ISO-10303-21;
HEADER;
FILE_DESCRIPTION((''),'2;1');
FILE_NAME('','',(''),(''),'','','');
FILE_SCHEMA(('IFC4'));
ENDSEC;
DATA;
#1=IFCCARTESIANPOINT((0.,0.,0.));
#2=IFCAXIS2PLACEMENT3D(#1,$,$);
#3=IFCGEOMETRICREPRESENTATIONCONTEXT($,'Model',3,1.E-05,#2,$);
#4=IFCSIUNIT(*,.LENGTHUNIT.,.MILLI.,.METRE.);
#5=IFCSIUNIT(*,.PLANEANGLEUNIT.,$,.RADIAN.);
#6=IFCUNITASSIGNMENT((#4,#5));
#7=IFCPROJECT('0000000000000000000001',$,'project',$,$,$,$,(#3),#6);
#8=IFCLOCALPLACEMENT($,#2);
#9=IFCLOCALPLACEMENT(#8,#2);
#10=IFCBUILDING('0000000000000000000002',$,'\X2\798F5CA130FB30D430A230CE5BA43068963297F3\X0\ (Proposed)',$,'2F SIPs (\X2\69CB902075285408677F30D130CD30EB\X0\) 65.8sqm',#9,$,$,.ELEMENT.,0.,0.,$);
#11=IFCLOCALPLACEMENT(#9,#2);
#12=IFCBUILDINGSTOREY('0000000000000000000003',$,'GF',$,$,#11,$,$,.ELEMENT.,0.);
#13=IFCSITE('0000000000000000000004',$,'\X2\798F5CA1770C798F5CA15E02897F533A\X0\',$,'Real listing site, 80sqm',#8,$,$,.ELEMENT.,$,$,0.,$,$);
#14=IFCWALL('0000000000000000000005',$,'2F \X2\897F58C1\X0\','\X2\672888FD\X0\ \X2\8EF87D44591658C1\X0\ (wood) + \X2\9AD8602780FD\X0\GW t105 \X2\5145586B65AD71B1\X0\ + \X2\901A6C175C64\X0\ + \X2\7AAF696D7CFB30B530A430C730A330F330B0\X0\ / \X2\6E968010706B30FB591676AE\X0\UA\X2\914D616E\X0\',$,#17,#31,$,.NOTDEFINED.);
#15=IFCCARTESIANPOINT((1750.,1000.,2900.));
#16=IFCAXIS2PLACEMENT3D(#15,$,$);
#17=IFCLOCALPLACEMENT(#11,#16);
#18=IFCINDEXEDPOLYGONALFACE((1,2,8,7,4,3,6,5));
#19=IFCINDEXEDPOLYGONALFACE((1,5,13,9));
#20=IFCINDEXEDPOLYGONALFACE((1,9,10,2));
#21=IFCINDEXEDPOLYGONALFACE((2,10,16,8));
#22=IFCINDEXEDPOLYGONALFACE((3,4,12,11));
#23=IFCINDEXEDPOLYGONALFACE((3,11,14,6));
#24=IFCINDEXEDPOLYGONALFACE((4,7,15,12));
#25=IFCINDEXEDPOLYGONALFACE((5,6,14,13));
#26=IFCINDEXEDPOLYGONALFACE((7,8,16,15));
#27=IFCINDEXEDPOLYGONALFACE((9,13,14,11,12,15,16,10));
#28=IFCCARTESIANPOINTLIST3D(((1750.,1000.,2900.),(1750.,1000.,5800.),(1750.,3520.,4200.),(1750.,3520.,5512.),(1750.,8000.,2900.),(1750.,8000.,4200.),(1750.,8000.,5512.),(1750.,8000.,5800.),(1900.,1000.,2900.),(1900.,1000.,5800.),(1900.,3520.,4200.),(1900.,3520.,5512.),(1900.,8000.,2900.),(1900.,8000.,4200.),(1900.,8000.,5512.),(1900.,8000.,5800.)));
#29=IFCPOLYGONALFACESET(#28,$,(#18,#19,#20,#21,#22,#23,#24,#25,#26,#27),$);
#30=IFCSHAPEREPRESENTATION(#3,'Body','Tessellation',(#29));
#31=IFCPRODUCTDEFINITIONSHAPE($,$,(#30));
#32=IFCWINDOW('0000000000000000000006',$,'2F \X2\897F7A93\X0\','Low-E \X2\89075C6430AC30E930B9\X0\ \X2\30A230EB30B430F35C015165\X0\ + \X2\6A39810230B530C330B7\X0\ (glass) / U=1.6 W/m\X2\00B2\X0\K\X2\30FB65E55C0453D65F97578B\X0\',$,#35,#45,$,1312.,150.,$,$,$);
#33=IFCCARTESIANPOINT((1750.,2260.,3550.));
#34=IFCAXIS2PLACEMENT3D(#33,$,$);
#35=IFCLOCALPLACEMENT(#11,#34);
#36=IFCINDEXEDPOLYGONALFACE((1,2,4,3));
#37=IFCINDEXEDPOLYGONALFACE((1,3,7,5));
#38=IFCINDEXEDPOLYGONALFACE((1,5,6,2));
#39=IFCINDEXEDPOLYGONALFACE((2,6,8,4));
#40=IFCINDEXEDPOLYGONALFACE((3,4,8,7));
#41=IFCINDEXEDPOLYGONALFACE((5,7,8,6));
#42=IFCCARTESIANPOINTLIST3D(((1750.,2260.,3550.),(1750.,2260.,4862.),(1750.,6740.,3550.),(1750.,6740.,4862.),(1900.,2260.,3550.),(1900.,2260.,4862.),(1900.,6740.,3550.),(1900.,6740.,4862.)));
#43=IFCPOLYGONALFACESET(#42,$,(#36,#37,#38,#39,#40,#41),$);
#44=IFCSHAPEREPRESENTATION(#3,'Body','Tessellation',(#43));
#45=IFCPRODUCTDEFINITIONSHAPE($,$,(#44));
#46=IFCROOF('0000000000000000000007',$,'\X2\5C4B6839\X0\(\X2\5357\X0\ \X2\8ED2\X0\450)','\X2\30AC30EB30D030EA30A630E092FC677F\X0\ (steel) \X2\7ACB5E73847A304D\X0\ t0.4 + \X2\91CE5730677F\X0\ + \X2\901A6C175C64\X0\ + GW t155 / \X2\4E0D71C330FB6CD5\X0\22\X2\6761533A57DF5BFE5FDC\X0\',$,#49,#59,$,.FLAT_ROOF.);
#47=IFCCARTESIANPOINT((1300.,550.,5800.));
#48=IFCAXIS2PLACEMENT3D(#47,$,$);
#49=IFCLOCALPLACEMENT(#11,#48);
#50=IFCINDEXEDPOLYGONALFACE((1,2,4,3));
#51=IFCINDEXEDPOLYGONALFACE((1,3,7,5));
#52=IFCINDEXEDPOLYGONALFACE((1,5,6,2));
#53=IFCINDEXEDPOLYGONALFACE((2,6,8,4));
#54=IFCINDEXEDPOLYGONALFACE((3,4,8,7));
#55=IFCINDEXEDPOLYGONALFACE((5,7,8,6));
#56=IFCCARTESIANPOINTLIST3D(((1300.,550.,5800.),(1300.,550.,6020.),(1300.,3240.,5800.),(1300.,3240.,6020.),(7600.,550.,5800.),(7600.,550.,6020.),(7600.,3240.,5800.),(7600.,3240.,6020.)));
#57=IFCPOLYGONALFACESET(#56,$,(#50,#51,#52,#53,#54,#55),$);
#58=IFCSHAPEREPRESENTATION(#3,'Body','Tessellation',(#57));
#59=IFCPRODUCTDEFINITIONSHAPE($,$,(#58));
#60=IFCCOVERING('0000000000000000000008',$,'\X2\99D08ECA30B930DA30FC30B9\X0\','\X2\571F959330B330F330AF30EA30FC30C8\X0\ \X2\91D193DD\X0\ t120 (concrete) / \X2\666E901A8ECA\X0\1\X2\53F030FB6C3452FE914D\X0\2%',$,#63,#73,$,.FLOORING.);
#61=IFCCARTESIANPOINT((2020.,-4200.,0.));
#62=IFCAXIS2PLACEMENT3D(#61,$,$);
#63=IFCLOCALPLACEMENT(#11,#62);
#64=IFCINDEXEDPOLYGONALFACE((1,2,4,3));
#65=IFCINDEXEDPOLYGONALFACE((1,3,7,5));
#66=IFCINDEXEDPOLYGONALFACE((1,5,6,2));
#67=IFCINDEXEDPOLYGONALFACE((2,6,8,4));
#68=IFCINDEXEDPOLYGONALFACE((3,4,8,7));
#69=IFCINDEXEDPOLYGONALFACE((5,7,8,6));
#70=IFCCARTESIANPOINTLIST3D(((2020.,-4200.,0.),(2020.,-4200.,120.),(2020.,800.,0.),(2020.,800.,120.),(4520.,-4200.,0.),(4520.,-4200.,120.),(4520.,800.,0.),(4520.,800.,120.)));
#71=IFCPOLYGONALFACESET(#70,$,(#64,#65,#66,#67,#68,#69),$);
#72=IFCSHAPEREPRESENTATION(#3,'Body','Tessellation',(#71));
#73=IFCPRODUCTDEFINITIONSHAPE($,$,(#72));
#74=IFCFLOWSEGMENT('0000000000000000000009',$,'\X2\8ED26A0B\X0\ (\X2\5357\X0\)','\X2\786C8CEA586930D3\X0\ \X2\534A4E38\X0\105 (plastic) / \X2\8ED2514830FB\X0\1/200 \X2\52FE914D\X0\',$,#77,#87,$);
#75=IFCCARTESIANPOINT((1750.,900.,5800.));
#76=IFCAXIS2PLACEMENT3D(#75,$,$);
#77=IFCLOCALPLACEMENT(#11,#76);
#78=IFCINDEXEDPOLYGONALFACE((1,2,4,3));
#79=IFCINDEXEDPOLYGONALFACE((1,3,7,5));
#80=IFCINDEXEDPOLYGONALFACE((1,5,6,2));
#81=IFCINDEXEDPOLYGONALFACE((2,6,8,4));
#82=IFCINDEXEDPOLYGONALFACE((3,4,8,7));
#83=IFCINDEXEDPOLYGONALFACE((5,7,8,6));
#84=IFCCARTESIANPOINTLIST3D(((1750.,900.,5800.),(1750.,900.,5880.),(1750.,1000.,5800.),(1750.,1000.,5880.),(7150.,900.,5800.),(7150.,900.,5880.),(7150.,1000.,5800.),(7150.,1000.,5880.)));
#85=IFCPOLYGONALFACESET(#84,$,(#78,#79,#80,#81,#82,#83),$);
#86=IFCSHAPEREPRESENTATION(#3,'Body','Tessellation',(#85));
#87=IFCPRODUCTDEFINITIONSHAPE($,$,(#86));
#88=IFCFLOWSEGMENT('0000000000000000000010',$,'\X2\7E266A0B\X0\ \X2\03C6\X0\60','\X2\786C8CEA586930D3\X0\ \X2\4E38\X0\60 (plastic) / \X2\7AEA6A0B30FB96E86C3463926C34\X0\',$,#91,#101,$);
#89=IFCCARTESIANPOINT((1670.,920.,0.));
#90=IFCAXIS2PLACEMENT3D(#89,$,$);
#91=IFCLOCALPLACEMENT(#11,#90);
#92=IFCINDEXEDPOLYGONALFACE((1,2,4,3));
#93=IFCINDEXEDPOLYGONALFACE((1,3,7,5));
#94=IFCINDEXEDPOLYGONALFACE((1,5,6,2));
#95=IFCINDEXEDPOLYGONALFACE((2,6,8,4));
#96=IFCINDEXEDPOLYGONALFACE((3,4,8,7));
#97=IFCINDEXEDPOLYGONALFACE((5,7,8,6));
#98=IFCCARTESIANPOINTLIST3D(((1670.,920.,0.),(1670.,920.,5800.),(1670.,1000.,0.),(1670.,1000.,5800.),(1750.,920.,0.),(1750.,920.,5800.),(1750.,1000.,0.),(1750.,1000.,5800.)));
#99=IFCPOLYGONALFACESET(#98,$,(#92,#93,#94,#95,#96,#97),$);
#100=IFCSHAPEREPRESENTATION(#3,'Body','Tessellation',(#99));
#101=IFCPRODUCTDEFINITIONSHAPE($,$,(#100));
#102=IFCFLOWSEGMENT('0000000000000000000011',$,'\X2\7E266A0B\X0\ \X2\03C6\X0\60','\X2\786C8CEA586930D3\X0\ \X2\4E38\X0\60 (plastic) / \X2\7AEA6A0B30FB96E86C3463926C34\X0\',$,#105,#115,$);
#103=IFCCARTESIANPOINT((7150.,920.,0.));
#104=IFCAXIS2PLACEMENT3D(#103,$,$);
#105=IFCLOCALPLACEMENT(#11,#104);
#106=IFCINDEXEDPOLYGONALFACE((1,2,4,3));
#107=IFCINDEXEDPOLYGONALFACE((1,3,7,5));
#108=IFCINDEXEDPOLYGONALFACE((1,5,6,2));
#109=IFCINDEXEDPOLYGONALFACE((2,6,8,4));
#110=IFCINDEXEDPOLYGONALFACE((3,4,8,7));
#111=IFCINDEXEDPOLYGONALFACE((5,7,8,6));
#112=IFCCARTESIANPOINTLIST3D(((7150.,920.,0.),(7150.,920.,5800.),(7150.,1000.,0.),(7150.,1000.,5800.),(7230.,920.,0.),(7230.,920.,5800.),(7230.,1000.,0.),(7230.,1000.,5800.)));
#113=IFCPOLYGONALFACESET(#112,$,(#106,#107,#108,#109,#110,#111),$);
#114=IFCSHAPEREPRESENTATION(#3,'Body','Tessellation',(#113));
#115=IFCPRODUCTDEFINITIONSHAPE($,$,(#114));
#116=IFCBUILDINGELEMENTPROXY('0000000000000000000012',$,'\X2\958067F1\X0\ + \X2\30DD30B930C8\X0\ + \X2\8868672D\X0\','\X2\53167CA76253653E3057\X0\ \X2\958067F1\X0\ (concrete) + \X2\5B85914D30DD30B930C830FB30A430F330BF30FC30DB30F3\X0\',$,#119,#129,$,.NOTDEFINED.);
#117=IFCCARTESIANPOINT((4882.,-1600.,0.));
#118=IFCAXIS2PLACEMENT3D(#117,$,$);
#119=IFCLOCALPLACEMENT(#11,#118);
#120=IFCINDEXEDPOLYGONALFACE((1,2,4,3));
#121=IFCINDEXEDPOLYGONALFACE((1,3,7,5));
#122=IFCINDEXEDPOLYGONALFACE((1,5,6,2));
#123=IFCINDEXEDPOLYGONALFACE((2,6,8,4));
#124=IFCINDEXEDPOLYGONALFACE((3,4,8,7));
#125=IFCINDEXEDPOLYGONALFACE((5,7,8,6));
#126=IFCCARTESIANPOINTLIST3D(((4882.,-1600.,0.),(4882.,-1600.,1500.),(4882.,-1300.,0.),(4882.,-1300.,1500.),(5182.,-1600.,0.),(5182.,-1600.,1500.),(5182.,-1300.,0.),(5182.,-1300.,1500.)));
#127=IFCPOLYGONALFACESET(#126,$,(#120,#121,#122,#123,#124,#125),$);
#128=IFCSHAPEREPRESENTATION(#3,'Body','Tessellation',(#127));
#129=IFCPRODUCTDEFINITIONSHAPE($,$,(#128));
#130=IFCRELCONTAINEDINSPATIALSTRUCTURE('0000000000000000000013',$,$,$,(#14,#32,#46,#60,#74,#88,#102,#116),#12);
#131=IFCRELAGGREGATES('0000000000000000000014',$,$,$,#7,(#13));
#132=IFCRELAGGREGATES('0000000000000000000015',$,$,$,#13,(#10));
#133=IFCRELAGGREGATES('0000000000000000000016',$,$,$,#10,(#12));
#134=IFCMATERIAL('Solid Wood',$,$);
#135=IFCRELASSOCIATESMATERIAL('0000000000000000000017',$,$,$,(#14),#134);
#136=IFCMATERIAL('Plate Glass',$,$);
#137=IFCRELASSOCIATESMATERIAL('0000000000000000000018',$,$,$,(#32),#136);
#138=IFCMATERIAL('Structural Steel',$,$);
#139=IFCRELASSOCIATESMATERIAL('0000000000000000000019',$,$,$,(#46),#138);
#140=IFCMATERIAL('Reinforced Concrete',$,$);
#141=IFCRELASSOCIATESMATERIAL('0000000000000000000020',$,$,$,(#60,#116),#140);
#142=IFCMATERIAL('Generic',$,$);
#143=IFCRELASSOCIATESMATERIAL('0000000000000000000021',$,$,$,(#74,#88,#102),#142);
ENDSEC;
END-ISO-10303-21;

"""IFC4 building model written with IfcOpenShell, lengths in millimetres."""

from ifc_helpers import new_model, si_unit, frame, frame_2d, origin, place, context, project, spatial, rectangle, extrude, material, element, fill, save


model = new_model("IFC4")

# Units and contexts
model_context = context("Model", 3, precision=1e-05, world=origin())
ifc_project = project(units=[si_unit("LENGTHUNIT", "METRE", prefix="MILLI"), si_unit("PLANEANGLEUNIT", "RADIAN")], contexts=[model_context])

# Site, building, storey
site_placement = place(None, origin())
site = spatial("IfcSite", under=ifc_project, at=site_placement, Name="福岡県福岡市西区", ObjectType="Real listing site, 80sqm", CompositionType="ELEMENT", RefElevation=0.0)
building_placement = place(site_placement, origin())
building = spatial("IfcBuilding", under=site, at=building_placement, Name="福岡・ピアノ室と防音 (Proposed)", ObjectType="2F SIPs (構造用合板パネル) 65.8sqm", CompositionType="ELEMENT", ElevationOfRefHeight=0.0, ElevationOfTerrain=0.0)
storey_placement = place(building_placement, origin())
storey = spatial("IfcBuildingStorey", under=building, at=storey_placement, Name="GF", CompositionType="ELEMENT", Elevation=0.0)

# Shared definitions
ifc_material_1 = material(Name="Solid Wood")

# Shared definitions
ifc_material_2 = material(Name="Reinforced Concrete")

# Shared definitions
ifc_material_3 = material(Name="Plate Glass")

# Wall, opening, window
wall_1_placement = place(storey_placement, frame((1750.0, 1000.0, 2900.0)))
wall_1 = element("IfcWall", 1, at=wall_1_placement, inside=storey, material=ifc_material_1, Name="2F 西壁", Description="木製 軸組外壁 (wood) + 高性能GW t105 充填断熱 + 通気層 + 窯業系サイディング / 準耐火・外皮UA配慮", PredefinedType="NOTDEFINED", context=model_context, shape_type="SweptSolid", body=[
    extrude(rectangle(XDim=150.0, YDim=7000.0, at=frame_2d((75.0, 3500.0))), frame((1750.0, 1000.0, 2900.0)), (0.0, 0.0, 1.0), 2900.0),
])
opening_1_placement = place(storey_placement, frame((1750.0, 2260.0, 3550.0)))
opening_1 = element("IfcOpeningElement", 2, at=opening_1_placement, cuts=wall_1, PredefinedType="NOTDEFINED", context=model_context, shape_type="SweptSolid", body=[
    extrude(rectangle(XDim=150.0, YDim=4480.0, at=frame_2d((75.0, 2240.0))), frame((1750.0, 2260.0, 3550.0)), (0.0, 0.0, 1.0), 1312.0),
])
window_1_placement = place(storey_placement, frame((1750.0, 2260.0, 3550.0)))
window_1 = element("IfcWindow", 3, at=window_1_placement, inside=storey, material=ifc_material_3, Name="2F 西窓", Description="Low-E 複層ガラス アルゴン封入 + 樹脂サッシ (glass) / U=1.6 W/m²K・日射取得型", OverallHeight=1312.0, OverallWidth=150.0, context=model_context, shape_type="SweptSolid", body=[
    extrude(rectangle(XDim=150.0, YDim=4480.0, at=frame_2d((75.0, 2240.0))), frame((1750.0, 2260.0, 3550.0)), (0.0, 0.0, 1.0), 1312.0),
])
fill(opening_1, window_1)

# Roof
ifc_material_4 = material(Name="Structural Steel")
for number, where, name in (
    (4, (1300.0, 550.0, 5800.0), "屋根(南 軒450)"),
):
    element("IfcRoof", number, at=place(storey_placement, frame(where)), inside=storey, material=ifc_material_4, Name=name, Description="ガルバリウム鋼板 (steel) 立平葺き t0.4 + 野地板 + 通気層 + GW t155 / 不燃・法22条区域対応", PredefinedType="FLAT_ROOF", context=model_context, shape_type="SweptSolid", body=[
        extrude(rectangle(XDim=6300.0, YDim=2690.0, at=frame_2d((3150.0, 1345.0))), frame((1300.0, 550.0, 5800.0)), (0.0, 0.0, 1.0), 220.0),
    ])

# Covering
covering_1_placement = place(storey_placement, frame((2020.0, -4200.0, 0.0)))
element("IfcCovering", 5, at=covering_1_placement, inside=storey, material=ifc_material_2, Name="駐車スペース", Description="土間コンクリート 金鏝 t120 (concrete) / 普通車1台・水勾配2%", PredefinedType="FLOORING", context=model_context, shape_type="SweptSolid", body=[
    extrude(rectangle(XDim=2500.0, YDim=5000.0, at=frame_2d((1250.0, 2500.0))), frame((2020.0, -4200.0, 0.0)), (0.0, 0.0, 1.0), 120.0),
])

# Flow segments
ifc_material_5 = material(Name="Generic")
flow_segment_1_placement = place(storey_placement, frame((1750.0, 900.0, 5800.0)))
element("IfcFlowSegment", 6, at=flow_segment_1_placement, inside=storey, material=ifc_material_5, Name="軒樋 (南)", Description="硬質塩ビ 半丸105 (plastic) / 軒先・1/200 勾配", context=model_context, shape_type="SweptSolid", body=[
    extrude(rectangle(XDim=5400.0, YDim=100.0, at=frame_2d((2700.0, 50.0))), frame((1750.0, 900.0, 5800.0)), (0.0, 0.0, 1.0), 80.0),
])
flow_segment_2_placement = place(storey_placement, frame((1670.0, 920.0, 0.0)))
element("IfcFlowSegment", 7, at=flow_segment_2_placement, inside=storey, material=ifc_material_5, Name="縦樋 φ60", Description="硬質塩ビ 丸60 (plastic) / 竪樋・雨水排水", context=model_context, shape_type="SweptSolid", body=[
    extrude(rectangle(XDim=80.0, YDim=80.0, at=frame_2d((40.0, 40.0))), frame((1670.0, 920.0, 0.0)), (0.0, 0.0, 1.0), 5800.0),
])
flow_segment_3_placement = place(storey_placement, frame((7150.0, 920.0, 0.0)))
element("IfcFlowSegment", 8, at=flow_segment_3_placement, inside=storey, material=ifc_material_5, Name="縦樋 φ60", Description="硬質塩ビ 丸60 (plastic) / 竪樋・雨水排水", context=model_context, shape_type="SweptSolid", body=[
    extrude(rectangle(XDim=80.0, YDim=80.0, at=frame_2d((40.0, 40.0))), frame((7150.0, 920.0, 0.0)), (0.0, 0.0, 1.0), 5800.0),
])

# Building element proxy
proxy_placement = place(storey_placement, frame((4882.0, -1600.0, 0.0)))
element("IfcBuildingElementProxy", 9, at=proxy_placement, inside=storey, material=ifc_material_2, Name="門柱 + ポスト + 表札", Description="化粧打放し 門柱 (concrete) + 宅配ポスト・インターホン", PredefinedType="NOTDEFINED", context=model_context, shape_type="SweptSolid", body=[
    extrude(rectangle(XDim=300.0, YDim=300.0, at=frame_2d((150.0, 150.0))), frame((4882.0, -1600.0, 0.0)), (0.0, 0.0, 1.0), 1500.0),
])

save(model, "model.ifc")
